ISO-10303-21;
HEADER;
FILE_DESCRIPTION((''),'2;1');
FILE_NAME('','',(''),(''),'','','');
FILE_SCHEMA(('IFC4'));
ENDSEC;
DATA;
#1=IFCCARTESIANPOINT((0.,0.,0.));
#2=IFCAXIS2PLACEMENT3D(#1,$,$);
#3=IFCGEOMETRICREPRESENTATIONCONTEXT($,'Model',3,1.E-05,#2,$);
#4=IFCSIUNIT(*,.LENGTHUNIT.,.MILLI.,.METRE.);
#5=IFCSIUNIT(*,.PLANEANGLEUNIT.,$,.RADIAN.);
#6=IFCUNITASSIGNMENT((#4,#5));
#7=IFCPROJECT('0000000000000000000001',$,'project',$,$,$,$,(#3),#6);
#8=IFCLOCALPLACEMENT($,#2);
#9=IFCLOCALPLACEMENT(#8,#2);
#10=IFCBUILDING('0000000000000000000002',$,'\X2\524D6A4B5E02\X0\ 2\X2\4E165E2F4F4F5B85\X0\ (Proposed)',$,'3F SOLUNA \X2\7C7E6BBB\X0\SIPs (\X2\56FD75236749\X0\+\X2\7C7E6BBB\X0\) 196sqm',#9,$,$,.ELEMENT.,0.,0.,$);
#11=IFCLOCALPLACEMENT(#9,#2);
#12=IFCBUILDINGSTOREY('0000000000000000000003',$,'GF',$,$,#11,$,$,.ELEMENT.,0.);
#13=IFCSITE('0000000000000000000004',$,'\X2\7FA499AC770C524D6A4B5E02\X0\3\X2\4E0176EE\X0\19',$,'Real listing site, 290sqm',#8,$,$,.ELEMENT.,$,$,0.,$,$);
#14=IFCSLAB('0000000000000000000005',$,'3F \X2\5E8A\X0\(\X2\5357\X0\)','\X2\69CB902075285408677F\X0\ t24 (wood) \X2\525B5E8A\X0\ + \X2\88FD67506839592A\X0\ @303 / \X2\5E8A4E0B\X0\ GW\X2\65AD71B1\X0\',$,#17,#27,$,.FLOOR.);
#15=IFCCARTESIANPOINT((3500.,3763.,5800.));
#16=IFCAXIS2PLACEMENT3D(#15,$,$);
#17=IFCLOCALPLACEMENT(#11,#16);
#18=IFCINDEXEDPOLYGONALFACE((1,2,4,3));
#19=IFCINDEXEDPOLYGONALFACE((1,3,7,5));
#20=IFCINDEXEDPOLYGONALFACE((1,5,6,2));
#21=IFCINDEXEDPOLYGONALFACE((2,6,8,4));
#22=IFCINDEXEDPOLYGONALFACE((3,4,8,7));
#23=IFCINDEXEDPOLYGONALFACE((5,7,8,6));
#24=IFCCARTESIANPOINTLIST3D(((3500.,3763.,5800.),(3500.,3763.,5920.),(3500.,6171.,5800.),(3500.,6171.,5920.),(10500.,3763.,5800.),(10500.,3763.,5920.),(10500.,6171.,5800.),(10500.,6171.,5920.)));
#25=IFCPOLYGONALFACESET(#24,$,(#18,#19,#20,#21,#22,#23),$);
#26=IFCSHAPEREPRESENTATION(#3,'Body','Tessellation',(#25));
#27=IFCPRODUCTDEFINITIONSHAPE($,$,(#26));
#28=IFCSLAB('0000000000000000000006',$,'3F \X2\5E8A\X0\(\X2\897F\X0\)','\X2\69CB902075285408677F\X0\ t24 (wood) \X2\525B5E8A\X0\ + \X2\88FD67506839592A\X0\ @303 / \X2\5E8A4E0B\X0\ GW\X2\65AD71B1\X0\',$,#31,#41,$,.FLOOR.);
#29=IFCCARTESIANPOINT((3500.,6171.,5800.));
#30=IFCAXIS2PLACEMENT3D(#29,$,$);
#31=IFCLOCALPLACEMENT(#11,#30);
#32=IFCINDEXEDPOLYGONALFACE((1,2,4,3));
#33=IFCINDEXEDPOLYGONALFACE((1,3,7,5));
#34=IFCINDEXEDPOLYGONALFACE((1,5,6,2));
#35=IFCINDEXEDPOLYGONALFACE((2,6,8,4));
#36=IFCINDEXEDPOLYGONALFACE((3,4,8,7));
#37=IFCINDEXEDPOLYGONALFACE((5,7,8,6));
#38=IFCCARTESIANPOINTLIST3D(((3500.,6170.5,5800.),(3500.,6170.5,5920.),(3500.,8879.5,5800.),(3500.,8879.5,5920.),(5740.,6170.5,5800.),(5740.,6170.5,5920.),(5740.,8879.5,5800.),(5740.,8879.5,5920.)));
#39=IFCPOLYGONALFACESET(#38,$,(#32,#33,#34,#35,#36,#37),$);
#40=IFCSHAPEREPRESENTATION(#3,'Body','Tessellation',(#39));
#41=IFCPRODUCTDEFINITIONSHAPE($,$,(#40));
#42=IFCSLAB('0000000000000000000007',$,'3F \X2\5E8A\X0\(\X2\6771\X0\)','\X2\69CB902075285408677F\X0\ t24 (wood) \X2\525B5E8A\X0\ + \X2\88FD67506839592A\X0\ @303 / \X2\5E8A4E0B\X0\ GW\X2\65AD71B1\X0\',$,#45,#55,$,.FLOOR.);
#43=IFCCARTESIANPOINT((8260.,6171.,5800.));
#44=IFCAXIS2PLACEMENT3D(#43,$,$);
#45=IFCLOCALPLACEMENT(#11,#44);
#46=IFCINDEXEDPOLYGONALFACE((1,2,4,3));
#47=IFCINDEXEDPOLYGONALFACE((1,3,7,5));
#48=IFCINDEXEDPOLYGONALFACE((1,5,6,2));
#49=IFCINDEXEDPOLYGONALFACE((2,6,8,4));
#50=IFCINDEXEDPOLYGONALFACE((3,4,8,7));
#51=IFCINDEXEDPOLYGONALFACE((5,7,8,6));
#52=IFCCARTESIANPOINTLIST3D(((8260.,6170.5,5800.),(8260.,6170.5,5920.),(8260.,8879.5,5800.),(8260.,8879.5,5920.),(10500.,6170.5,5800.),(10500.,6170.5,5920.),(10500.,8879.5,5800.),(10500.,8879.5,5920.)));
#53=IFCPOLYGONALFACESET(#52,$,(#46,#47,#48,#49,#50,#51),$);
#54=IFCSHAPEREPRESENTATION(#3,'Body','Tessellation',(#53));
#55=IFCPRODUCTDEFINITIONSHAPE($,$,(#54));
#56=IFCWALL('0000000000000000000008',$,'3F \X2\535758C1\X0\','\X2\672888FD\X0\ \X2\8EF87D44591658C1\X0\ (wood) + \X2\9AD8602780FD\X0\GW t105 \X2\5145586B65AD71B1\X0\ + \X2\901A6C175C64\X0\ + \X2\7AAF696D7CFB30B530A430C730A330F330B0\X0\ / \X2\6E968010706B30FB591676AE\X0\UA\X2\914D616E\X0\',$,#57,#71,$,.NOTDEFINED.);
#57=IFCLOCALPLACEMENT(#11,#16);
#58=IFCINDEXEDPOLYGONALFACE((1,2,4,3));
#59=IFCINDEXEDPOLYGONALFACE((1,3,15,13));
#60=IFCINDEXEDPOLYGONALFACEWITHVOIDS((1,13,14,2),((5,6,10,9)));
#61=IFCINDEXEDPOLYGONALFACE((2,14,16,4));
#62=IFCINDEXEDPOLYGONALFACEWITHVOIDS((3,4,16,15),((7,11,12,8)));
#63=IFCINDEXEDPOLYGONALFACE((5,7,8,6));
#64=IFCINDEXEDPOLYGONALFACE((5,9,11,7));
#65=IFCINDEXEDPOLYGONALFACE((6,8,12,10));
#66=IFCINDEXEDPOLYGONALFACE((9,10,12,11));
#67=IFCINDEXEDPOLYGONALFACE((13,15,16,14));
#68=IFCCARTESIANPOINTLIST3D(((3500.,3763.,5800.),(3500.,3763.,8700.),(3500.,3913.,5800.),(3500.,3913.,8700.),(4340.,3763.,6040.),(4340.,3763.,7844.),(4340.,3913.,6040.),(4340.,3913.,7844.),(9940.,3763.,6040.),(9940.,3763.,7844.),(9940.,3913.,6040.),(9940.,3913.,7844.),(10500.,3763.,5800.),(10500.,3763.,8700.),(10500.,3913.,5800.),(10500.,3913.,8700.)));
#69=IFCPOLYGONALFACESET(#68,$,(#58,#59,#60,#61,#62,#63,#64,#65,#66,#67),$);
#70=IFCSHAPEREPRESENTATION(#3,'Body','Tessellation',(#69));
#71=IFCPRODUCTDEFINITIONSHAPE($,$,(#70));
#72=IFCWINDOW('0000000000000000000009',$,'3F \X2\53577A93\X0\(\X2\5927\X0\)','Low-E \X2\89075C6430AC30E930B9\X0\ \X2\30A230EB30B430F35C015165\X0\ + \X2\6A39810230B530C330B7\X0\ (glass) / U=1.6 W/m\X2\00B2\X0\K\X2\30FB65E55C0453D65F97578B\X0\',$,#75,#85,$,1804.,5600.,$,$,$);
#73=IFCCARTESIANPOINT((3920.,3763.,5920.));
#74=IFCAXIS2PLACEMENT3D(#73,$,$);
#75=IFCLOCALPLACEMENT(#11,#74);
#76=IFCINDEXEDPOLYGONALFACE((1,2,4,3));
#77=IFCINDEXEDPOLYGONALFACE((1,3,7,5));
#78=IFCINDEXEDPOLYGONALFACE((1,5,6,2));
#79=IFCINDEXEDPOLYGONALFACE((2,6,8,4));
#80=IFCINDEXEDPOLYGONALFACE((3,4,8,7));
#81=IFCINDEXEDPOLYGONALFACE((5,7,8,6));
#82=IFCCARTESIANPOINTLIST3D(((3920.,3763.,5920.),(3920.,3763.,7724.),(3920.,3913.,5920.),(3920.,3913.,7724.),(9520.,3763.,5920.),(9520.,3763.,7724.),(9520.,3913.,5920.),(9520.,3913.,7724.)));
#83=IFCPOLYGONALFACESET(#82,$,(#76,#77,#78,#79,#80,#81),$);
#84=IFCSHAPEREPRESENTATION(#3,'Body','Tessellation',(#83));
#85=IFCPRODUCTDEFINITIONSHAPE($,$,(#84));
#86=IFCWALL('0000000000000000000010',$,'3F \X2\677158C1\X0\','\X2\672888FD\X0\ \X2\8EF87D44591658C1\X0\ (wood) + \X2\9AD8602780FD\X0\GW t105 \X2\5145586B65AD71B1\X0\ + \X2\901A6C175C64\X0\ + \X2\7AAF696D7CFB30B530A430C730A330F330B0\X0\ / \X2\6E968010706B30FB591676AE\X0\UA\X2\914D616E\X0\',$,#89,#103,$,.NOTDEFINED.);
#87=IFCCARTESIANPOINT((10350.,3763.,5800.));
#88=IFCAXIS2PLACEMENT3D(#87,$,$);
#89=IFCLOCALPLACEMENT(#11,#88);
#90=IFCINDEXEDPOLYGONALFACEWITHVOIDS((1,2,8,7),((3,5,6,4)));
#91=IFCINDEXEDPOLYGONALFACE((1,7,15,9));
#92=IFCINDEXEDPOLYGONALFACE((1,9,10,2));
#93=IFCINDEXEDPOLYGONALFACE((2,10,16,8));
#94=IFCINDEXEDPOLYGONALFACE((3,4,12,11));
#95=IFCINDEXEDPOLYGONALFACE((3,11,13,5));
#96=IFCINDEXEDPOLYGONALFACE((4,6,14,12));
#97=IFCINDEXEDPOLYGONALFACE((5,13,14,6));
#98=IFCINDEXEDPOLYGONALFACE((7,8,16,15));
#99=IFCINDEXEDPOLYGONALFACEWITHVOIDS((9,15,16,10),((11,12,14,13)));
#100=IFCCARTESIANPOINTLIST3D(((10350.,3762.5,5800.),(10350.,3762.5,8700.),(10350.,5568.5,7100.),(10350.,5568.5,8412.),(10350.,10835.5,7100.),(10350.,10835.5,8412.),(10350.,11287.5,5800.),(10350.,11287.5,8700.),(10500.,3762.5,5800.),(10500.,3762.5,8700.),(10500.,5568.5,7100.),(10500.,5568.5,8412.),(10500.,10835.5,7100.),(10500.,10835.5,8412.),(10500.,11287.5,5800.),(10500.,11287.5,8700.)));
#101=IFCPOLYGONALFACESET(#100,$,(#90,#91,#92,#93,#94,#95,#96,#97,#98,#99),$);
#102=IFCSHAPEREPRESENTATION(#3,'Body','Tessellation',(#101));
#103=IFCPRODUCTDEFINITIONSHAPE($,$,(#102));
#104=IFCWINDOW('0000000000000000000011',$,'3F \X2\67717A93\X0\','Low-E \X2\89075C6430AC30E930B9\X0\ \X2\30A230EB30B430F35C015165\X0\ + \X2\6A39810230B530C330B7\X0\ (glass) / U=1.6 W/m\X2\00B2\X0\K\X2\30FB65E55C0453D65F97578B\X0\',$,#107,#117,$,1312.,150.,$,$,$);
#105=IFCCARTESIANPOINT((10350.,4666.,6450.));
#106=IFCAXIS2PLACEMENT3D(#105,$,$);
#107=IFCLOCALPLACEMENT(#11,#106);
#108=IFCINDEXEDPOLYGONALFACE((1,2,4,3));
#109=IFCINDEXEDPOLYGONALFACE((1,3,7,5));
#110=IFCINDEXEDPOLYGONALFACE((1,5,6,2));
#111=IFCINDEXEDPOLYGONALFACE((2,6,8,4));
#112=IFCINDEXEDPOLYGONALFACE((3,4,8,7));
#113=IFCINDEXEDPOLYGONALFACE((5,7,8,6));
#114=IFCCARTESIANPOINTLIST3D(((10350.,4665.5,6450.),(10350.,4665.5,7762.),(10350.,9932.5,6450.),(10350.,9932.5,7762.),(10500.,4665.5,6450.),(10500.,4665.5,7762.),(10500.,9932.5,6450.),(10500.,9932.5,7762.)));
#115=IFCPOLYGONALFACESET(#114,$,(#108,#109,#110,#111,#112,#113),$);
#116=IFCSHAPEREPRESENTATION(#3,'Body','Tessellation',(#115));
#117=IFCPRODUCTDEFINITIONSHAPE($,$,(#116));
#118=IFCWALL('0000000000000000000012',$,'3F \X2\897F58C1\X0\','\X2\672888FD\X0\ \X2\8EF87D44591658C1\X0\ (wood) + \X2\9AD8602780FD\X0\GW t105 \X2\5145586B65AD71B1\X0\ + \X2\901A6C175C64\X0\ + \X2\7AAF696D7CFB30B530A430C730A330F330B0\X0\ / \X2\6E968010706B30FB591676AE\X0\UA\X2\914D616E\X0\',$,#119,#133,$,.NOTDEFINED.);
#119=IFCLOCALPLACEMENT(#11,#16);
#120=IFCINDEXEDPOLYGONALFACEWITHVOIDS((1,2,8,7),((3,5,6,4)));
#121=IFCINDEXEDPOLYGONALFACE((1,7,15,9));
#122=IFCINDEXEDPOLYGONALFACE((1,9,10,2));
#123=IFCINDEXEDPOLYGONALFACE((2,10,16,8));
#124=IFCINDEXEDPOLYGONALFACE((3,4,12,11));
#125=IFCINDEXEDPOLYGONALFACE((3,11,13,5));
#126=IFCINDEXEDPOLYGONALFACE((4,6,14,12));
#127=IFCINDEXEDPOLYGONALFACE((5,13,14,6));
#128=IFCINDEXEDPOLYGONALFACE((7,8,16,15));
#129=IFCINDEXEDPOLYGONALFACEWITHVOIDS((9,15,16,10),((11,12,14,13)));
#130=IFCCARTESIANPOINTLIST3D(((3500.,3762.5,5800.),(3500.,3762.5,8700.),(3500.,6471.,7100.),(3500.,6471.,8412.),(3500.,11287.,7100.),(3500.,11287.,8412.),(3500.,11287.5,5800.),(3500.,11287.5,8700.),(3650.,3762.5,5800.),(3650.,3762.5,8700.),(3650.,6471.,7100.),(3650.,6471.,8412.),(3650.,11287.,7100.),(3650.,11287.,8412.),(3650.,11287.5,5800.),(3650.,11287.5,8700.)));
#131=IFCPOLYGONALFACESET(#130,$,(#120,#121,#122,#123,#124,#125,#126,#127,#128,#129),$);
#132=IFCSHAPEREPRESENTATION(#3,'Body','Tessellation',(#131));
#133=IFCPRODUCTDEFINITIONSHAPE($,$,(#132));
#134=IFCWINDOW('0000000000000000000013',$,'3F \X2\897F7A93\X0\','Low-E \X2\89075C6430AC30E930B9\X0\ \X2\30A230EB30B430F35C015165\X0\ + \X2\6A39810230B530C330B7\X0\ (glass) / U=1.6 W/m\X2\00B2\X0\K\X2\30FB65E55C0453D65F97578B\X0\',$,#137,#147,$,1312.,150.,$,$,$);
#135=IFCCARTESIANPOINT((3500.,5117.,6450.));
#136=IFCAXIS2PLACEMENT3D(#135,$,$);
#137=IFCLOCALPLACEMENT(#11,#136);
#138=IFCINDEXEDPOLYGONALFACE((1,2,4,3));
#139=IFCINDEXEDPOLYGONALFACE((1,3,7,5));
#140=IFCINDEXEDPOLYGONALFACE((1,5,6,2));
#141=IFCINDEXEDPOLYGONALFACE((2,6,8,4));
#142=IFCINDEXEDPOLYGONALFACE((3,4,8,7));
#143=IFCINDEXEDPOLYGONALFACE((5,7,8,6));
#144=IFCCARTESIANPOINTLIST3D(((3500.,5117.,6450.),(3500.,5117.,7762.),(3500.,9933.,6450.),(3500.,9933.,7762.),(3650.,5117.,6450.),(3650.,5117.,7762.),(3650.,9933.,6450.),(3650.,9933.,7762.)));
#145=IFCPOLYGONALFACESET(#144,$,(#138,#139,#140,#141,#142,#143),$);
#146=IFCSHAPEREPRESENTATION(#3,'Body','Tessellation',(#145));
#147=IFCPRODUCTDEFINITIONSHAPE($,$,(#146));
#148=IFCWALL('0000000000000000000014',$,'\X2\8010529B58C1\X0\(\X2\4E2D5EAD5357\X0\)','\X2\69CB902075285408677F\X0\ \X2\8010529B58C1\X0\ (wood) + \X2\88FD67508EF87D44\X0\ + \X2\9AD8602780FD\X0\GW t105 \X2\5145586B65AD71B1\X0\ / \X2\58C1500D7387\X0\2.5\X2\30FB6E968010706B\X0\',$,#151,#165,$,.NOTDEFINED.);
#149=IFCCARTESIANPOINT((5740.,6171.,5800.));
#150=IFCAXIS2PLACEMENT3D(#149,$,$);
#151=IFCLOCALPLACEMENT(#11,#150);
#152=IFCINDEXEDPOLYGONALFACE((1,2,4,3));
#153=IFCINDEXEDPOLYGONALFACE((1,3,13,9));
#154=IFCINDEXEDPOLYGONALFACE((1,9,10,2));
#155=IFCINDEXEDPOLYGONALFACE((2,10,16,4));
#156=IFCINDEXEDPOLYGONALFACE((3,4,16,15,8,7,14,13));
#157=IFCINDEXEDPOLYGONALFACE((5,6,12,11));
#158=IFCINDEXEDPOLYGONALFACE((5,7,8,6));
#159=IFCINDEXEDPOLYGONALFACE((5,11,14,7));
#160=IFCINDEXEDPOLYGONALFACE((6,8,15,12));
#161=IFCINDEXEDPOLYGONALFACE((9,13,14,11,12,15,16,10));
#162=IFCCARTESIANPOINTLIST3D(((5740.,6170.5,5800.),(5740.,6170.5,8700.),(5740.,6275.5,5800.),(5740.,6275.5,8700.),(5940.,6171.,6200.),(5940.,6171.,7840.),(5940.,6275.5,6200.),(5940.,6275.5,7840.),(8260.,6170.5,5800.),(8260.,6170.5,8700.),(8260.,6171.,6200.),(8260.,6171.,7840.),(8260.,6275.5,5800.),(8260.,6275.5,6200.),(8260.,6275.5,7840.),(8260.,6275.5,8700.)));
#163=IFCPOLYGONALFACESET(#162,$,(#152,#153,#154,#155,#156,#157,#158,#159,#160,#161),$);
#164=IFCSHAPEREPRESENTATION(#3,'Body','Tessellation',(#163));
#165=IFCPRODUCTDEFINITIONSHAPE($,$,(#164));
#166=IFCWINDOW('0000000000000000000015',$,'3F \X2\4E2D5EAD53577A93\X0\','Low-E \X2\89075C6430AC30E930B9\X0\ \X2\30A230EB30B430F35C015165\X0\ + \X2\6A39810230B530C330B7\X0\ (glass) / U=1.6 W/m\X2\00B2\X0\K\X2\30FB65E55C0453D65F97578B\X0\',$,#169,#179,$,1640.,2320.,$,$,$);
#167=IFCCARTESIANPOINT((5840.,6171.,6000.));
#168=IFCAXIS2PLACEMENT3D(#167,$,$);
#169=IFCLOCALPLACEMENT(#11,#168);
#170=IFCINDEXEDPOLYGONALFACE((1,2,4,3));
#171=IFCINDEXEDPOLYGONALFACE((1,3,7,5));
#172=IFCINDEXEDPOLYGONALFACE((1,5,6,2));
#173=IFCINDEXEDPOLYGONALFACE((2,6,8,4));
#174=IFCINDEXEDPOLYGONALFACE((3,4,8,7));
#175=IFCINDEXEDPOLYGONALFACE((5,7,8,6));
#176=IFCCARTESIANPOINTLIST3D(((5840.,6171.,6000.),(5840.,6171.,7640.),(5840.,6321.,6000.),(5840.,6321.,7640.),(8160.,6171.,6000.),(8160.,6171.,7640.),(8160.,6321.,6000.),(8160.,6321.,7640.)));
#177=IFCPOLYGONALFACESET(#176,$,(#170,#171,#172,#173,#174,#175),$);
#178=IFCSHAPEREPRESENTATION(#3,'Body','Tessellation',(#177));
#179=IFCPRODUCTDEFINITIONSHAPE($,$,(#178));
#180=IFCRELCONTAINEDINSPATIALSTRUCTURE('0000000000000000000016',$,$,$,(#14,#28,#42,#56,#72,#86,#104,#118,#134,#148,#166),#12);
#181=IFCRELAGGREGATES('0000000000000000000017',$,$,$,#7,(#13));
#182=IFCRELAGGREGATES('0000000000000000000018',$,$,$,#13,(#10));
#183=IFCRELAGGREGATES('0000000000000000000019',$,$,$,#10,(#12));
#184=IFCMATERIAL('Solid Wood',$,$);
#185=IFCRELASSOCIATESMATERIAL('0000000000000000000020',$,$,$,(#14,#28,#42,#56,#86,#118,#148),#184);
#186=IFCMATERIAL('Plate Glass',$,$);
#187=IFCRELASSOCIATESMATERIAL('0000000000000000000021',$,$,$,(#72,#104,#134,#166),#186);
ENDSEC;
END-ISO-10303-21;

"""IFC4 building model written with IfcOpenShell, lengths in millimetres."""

from ifc_helpers import new_model, si_unit, frame, frame_2d, origin, place, context, project, spatial, rectangle, extrude, material, element, fill, save


model = new_model("IFC4")

# Units and contexts
model_context = context("Model", 3, precision=1e-05, world=origin())
ifc_project = project(units=[si_unit("LENGTHUNIT", "METRE", prefix="MILLI"), si_unit("PLANEANGLEUNIT", "RADIAN")], contexts=[model_context])

# Site, building, storey
site_placement = place(None, origin())
site = spatial("IfcSite", under=ifc_project, at=site_placement, Name="群馬県前橋市3丁目19", ObjectType="Real listing site, 290sqm", CompositionType="ELEMENT", RefElevation=0.0)
building_placement = place(site_placement, origin())
building = spatial("IfcBuilding", under=site, at=building_placement, Name="前橋市 2世帯住宅 (Proposed)", ObjectType="3F SOLUNA 籾殻SIPs (国産杉+籾殻) 196sqm", CompositionType="ELEMENT", ElevationOfRefHeight=0.0, ElevationOfTerrain=0.0)
storey_placement = place(building_placement, origin())
storey = spatial("IfcBuildingStorey", under=building, at=storey_placement, Name="GF", CompositionType="ELEMENT", Elevation=0.0)

# Slabs
ifc_material_1 = material(Name="Solid Wood")
slab_1_placement = place(storey_placement, frame((3500.0, 3763.0, 5800.0)))
element("IfcSlab", 1, at=slab_1_placement, inside=storey, material=ifc_material_1, Name="3F 床(南)", Description="構造用合板 t24 (wood) 剛床 + 製材根太 @303 / 床下 GW断熱", PredefinedType="FLOOR", context=model_context, shape_type="SweptSolid", body=[
    extrude(rectangle(XDim=7000.0, YDim=2408.0, at=frame_2d((3500.0, 1204.0))), frame((3500.0, 3763.0, 5800.0)), (0.0, 0.0, 1.0), 120.0),
])
slab_2_placement = place(storey_placement, frame((3500.0, 6171.0, 5800.0)))
element("IfcSlab", 2, at=slab_2_placement, inside=storey, material=ifc_material_1, Name="3F 床(西)", Description="構造用合板 t24 (wood) 剛床 + 製材根太 @303 / 床下 GW断熱", PredefinedType="FLOOR", context=model_context, shape_type="SweptSolid", body=[
    extrude(rectangle(XDim=2240.0, YDim=2709.0, at=frame_2d((1120.0, 1354.0))), frame((3500.0, 6171.0, 5800.0)), (0.0, 0.0, 1.0), 120.0),
])
slab_3_placement = place(storey_placement, frame((8260.0, 6171.0, 5800.0)))
element("IfcSlab", 3, at=slab_3_placement, inside=storey, material=ifc_material_1, Name="3F 床(東)", Description="構造用合板 t24 (wood) 剛床 + 製材根太 @303 / 床下 GW断熱", PredefinedType="FLOOR", context=model_context, shape_type="SweptSolid", body=[
    extrude(rectangle(XDim=2240.0, YDim=2709.0, at=frame_2d((1120.0, 1354.0))), frame((8260.0, 6171.0, 5800.0)), (0.0, 0.0, 1.0), 120.0),
])

# Walls, openings, windows
wall_1_placement = place(storey_placement, frame((3500.0, 3763.0, 5800.0)))
wall_1 = element("IfcWall", 4, at=wall_1_placement, inside=storey, material=ifc_material_1, Name="3F 南壁", Description="木製 軸組外壁 (wood) + 高性能GW t105 充填断熱 + 通気層 + 窯業系サイディング / 準耐火・外皮UA配慮", PredefinedType="NOTDEFINED", context=model_context, shape_type="SweptSolid", body=[
    extrude(rectangle(XDim=7000.0, YDim=150.0, at=frame_2d((3500.0, 75.0))), frame((3500.0, 3763.0, 5800.0)), (0.0, 0.0, 1.0), 2900.0),
])
opening_1_placement = place(storey_placement, frame((3920.0, 3763.0, 5920.0)))
opening_1 = element("IfcOpeningElement", 5, at=opening_1_placement, cuts=wall_1, PredefinedType="NOTDEFINED", context=model_context, shape_type="SweptSolid", body=[
    extrude(rectangle(XDim=5600.0, YDim=150.0, at=frame_2d((2800.0, 75.0))), frame((3920.0, 3763.0, 5920.0)), (0.0, 0.0, 1.0), 1804.0),
])
ifc_material_2 = material(Name="Plate Glass")
window_1_placement = place(storey_placement, frame((3920.0, 3763.0, 5920.0)))
window_1 = element("IfcWindow", 6, at=window_1_placement, inside=storey, material=ifc_material_2, Name="3F 南窓(大)", Description="Low-E 複層ガラス アルゴン封入 + 樹脂サッシ (glass) / U=1.6 W/m²K・日射取得型", OverallHeight=1804.0, OverallWidth=5600.0, context=model_context, shape_type="SweptSolid", body=[
    extrude(rectangle(XDim=5600.0, YDim=150.0, at=frame_2d((2800.0, 75.0))), frame((3920.0, 3763.0, 5920.0)), (0.0, 0.0, 1.0), 1804.0),
])
fill(opening_1, window_1)
wall_2_placement = place(storey_placement, frame((10350.0, 3763.0, 5800.0)))
wall_2 = element("IfcWall", 7, at=wall_2_placement, inside=storey, material=ifc_material_1, Name="3F 東壁", Description="木製 軸組外壁 (wood) + 高性能GW t105 充填断熱 + 通気層 + 窯業系サイディング / 準耐火・外皮UA配慮", PredefinedType="NOTDEFINED", context=model_context, shape_type="SweptSolid", body=[
    extrude(rectangle(XDim=150.0, YDim=7525.0, at=frame_2d((75.0, 3762.0))), frame((10350.0, 3763.0, 5800.0)), (0.0, 0.0, 1.0), 2900.0),
])
opening_2_placement = place(storey_placement, frame((10350.0, 4666.0, 6450.0)))
opening_2 = element("IfcOpeningElement", 8, at=opening_2_placement, cuts=wall_2, PredefinedType="NOTDEFINED", context=model_context, shape_type="SweptSolid", body=[
    extrude(rectangle(XDim=150.0, YDim=5267.0, at=frame_2d((75.0, 2633.0))), frame((10350.0, 4666.0, 6450.0)), (0.0, 0.0, 1.0), 1312.0),
])
window_2_placement = place(storey_placement, frame((10350.0, 4666.0, 6450.0)))
window_2 = element("IfcWindow", 9, at=window_2_placement, inside=storey, material=ifc_material_2, Name="3F 東窓", Description="Low-E 複層ガラス アルゴン封入 + 樹脂サッシ (glass) / U=1.6 W/m²K・日射取得型", OverallHeight=1312.0, OverallWidth=150.0, context=model_context, shape_type="SweptSolid", body=[
    extrude(rectangle(XDim=150.0, YDim=5267.0, at=frame_2d((75.0, 2633.0))), frame((10350.0, 4666.0, 6450.0)), (0.0, 0.0, 1.0), 1312.0),
])
fill(opening_2, window_2)
wall_3_placement = place(storey_placement, frame((3500.0, 3763.0, 5800.0)))
wall_3 = element("IfcWall", 10, at=wall_3_placement, inside=storey, material=ifc_material_1, Name="3F 西壁", Description="木製 軸組外壁 (wood) + 高性能GW t105 充填断熱 + 通気層 + 窯業系サイディング / 準耐火・外皮UA配慮", PredefinedType="NOTDEFINED", context=model_context, shape_type="SweptSolid", body=[
    extrude(rectangle(XDim=150.0, YDim=7525.0, at=frame_2d((75.0, 3762.0))), frame((3500.0, 3763.0, 5800.0)), (0.0, 0.0, 1.0), 2900.0),
])
opening_3_placement = place(storey_placement, frame((3500.0, 5117.0, 6450.0)))
opening_3 = element("IfcOpeningElement", 11, at=opening_3_placement, cuts=wall_3, PredefinedType="NOTDEFINED", context=model_context, shape_type="SweptSolid", body=[
    extrude(rectangle(XDim=150.0, YDim=4816.0, at=frame_2d((75.0, 2408.0))), frame((3500.0, 5117.0, 6450.0)), (0.0, 0.0, 1.0), 1312.0),
])
window_3_placement = place(storey_placement, frame((3500.0, 5117.0, 6450.0)))
window_3 = element("IfcWindow", 12, at=window_3_placement, inside=storey, material=ifc_material_2, Name="3F 西窓", Description="Low-E 複層ガラス アルゴン封入 + 樹脂サッシ (glass) / U=1.6 W/m²K・日射取得型", OverallHeight=1312.0, OverallWidth=150.0, context=model_context, shape_type="SweptSolid", body=[
    extrude(rectangle(XDim=150.0, YDim=4816.0, at=frame_2d((75.0, 2408.0))), frame((3500.0, 5117.0, 6450.0)), (0.0, 0.0, 1.0), 1312.0),
])
fill(opening_3, window_3)
wall_4_placement = place(storey_placement, frame((5740.0, 6171.0, 5800.0)))
wall_4 = element("IfcWall", 13, at=wall_4_placement, inside=storey, material=ifc_material_1, Name="耐力壁(中庭南)", Description="構造用合板 耐力壁 (wood) + 製材軸組 + 高性能GW t105 充填断熱 / 壁倍率2.5・準耐火", PredefinedType="NOTDEFINED", context=model_context, shape_type="SweptSolid", body=[
    extrude(rectangle(XDim=2520.0, YDim=105.0, at=frame_2d((1260.0, 52.0))), frame((5740.0, 6171.0, 5800.0)), (0.0, 0.0, 1.0), 2900.0),
])
opening_4_placement = place(storey_placement, frame((5840.0, 6171.0, 6000.0)))
opening_4 = element("IfcOpeningElement", 14, at=opening_4_placement, cuts=wall_4, PredefinedType="NOTDEFINED", context=model_context, shape_type="SweptSolid", body=[
    extrude(rectangle(XDim=2320.0, YDim=150.0, at=frame_2d((1160.0, 75.0))), frame((5840.0, 6171.0, 6000.0)), (0.0, 0.0, 1.0), 1640.0),
])
window_4_placement = place(storey_placement, frame((5840.0, 6171.0, 6000.0)))
window_4 = element("IfcWindow", 15, at=window_4_placement, inside=storey, material=ifc_material_2, Name="3F 中庭南窓", Description="Low-E 複層ガラス アルゴン封入 + 樹脂サッシ (glass) / U=1.6 W/m²K・日射取得型", OverallHeight=1640.0, OverallWidth=2320.0, context=model_context, shape_type="SweptSolid", body=[
    extrude(rectangle(XDim=2320.0, YDim=150.0, at=frame_2d((1160.0, 75.0))), frame((5840.0, 6171.0, 6000.0)), (0.0, 0.0, 1.0), 1640.0),
])
fill(opening_4, window_4)

save(model, "model.ifc")
